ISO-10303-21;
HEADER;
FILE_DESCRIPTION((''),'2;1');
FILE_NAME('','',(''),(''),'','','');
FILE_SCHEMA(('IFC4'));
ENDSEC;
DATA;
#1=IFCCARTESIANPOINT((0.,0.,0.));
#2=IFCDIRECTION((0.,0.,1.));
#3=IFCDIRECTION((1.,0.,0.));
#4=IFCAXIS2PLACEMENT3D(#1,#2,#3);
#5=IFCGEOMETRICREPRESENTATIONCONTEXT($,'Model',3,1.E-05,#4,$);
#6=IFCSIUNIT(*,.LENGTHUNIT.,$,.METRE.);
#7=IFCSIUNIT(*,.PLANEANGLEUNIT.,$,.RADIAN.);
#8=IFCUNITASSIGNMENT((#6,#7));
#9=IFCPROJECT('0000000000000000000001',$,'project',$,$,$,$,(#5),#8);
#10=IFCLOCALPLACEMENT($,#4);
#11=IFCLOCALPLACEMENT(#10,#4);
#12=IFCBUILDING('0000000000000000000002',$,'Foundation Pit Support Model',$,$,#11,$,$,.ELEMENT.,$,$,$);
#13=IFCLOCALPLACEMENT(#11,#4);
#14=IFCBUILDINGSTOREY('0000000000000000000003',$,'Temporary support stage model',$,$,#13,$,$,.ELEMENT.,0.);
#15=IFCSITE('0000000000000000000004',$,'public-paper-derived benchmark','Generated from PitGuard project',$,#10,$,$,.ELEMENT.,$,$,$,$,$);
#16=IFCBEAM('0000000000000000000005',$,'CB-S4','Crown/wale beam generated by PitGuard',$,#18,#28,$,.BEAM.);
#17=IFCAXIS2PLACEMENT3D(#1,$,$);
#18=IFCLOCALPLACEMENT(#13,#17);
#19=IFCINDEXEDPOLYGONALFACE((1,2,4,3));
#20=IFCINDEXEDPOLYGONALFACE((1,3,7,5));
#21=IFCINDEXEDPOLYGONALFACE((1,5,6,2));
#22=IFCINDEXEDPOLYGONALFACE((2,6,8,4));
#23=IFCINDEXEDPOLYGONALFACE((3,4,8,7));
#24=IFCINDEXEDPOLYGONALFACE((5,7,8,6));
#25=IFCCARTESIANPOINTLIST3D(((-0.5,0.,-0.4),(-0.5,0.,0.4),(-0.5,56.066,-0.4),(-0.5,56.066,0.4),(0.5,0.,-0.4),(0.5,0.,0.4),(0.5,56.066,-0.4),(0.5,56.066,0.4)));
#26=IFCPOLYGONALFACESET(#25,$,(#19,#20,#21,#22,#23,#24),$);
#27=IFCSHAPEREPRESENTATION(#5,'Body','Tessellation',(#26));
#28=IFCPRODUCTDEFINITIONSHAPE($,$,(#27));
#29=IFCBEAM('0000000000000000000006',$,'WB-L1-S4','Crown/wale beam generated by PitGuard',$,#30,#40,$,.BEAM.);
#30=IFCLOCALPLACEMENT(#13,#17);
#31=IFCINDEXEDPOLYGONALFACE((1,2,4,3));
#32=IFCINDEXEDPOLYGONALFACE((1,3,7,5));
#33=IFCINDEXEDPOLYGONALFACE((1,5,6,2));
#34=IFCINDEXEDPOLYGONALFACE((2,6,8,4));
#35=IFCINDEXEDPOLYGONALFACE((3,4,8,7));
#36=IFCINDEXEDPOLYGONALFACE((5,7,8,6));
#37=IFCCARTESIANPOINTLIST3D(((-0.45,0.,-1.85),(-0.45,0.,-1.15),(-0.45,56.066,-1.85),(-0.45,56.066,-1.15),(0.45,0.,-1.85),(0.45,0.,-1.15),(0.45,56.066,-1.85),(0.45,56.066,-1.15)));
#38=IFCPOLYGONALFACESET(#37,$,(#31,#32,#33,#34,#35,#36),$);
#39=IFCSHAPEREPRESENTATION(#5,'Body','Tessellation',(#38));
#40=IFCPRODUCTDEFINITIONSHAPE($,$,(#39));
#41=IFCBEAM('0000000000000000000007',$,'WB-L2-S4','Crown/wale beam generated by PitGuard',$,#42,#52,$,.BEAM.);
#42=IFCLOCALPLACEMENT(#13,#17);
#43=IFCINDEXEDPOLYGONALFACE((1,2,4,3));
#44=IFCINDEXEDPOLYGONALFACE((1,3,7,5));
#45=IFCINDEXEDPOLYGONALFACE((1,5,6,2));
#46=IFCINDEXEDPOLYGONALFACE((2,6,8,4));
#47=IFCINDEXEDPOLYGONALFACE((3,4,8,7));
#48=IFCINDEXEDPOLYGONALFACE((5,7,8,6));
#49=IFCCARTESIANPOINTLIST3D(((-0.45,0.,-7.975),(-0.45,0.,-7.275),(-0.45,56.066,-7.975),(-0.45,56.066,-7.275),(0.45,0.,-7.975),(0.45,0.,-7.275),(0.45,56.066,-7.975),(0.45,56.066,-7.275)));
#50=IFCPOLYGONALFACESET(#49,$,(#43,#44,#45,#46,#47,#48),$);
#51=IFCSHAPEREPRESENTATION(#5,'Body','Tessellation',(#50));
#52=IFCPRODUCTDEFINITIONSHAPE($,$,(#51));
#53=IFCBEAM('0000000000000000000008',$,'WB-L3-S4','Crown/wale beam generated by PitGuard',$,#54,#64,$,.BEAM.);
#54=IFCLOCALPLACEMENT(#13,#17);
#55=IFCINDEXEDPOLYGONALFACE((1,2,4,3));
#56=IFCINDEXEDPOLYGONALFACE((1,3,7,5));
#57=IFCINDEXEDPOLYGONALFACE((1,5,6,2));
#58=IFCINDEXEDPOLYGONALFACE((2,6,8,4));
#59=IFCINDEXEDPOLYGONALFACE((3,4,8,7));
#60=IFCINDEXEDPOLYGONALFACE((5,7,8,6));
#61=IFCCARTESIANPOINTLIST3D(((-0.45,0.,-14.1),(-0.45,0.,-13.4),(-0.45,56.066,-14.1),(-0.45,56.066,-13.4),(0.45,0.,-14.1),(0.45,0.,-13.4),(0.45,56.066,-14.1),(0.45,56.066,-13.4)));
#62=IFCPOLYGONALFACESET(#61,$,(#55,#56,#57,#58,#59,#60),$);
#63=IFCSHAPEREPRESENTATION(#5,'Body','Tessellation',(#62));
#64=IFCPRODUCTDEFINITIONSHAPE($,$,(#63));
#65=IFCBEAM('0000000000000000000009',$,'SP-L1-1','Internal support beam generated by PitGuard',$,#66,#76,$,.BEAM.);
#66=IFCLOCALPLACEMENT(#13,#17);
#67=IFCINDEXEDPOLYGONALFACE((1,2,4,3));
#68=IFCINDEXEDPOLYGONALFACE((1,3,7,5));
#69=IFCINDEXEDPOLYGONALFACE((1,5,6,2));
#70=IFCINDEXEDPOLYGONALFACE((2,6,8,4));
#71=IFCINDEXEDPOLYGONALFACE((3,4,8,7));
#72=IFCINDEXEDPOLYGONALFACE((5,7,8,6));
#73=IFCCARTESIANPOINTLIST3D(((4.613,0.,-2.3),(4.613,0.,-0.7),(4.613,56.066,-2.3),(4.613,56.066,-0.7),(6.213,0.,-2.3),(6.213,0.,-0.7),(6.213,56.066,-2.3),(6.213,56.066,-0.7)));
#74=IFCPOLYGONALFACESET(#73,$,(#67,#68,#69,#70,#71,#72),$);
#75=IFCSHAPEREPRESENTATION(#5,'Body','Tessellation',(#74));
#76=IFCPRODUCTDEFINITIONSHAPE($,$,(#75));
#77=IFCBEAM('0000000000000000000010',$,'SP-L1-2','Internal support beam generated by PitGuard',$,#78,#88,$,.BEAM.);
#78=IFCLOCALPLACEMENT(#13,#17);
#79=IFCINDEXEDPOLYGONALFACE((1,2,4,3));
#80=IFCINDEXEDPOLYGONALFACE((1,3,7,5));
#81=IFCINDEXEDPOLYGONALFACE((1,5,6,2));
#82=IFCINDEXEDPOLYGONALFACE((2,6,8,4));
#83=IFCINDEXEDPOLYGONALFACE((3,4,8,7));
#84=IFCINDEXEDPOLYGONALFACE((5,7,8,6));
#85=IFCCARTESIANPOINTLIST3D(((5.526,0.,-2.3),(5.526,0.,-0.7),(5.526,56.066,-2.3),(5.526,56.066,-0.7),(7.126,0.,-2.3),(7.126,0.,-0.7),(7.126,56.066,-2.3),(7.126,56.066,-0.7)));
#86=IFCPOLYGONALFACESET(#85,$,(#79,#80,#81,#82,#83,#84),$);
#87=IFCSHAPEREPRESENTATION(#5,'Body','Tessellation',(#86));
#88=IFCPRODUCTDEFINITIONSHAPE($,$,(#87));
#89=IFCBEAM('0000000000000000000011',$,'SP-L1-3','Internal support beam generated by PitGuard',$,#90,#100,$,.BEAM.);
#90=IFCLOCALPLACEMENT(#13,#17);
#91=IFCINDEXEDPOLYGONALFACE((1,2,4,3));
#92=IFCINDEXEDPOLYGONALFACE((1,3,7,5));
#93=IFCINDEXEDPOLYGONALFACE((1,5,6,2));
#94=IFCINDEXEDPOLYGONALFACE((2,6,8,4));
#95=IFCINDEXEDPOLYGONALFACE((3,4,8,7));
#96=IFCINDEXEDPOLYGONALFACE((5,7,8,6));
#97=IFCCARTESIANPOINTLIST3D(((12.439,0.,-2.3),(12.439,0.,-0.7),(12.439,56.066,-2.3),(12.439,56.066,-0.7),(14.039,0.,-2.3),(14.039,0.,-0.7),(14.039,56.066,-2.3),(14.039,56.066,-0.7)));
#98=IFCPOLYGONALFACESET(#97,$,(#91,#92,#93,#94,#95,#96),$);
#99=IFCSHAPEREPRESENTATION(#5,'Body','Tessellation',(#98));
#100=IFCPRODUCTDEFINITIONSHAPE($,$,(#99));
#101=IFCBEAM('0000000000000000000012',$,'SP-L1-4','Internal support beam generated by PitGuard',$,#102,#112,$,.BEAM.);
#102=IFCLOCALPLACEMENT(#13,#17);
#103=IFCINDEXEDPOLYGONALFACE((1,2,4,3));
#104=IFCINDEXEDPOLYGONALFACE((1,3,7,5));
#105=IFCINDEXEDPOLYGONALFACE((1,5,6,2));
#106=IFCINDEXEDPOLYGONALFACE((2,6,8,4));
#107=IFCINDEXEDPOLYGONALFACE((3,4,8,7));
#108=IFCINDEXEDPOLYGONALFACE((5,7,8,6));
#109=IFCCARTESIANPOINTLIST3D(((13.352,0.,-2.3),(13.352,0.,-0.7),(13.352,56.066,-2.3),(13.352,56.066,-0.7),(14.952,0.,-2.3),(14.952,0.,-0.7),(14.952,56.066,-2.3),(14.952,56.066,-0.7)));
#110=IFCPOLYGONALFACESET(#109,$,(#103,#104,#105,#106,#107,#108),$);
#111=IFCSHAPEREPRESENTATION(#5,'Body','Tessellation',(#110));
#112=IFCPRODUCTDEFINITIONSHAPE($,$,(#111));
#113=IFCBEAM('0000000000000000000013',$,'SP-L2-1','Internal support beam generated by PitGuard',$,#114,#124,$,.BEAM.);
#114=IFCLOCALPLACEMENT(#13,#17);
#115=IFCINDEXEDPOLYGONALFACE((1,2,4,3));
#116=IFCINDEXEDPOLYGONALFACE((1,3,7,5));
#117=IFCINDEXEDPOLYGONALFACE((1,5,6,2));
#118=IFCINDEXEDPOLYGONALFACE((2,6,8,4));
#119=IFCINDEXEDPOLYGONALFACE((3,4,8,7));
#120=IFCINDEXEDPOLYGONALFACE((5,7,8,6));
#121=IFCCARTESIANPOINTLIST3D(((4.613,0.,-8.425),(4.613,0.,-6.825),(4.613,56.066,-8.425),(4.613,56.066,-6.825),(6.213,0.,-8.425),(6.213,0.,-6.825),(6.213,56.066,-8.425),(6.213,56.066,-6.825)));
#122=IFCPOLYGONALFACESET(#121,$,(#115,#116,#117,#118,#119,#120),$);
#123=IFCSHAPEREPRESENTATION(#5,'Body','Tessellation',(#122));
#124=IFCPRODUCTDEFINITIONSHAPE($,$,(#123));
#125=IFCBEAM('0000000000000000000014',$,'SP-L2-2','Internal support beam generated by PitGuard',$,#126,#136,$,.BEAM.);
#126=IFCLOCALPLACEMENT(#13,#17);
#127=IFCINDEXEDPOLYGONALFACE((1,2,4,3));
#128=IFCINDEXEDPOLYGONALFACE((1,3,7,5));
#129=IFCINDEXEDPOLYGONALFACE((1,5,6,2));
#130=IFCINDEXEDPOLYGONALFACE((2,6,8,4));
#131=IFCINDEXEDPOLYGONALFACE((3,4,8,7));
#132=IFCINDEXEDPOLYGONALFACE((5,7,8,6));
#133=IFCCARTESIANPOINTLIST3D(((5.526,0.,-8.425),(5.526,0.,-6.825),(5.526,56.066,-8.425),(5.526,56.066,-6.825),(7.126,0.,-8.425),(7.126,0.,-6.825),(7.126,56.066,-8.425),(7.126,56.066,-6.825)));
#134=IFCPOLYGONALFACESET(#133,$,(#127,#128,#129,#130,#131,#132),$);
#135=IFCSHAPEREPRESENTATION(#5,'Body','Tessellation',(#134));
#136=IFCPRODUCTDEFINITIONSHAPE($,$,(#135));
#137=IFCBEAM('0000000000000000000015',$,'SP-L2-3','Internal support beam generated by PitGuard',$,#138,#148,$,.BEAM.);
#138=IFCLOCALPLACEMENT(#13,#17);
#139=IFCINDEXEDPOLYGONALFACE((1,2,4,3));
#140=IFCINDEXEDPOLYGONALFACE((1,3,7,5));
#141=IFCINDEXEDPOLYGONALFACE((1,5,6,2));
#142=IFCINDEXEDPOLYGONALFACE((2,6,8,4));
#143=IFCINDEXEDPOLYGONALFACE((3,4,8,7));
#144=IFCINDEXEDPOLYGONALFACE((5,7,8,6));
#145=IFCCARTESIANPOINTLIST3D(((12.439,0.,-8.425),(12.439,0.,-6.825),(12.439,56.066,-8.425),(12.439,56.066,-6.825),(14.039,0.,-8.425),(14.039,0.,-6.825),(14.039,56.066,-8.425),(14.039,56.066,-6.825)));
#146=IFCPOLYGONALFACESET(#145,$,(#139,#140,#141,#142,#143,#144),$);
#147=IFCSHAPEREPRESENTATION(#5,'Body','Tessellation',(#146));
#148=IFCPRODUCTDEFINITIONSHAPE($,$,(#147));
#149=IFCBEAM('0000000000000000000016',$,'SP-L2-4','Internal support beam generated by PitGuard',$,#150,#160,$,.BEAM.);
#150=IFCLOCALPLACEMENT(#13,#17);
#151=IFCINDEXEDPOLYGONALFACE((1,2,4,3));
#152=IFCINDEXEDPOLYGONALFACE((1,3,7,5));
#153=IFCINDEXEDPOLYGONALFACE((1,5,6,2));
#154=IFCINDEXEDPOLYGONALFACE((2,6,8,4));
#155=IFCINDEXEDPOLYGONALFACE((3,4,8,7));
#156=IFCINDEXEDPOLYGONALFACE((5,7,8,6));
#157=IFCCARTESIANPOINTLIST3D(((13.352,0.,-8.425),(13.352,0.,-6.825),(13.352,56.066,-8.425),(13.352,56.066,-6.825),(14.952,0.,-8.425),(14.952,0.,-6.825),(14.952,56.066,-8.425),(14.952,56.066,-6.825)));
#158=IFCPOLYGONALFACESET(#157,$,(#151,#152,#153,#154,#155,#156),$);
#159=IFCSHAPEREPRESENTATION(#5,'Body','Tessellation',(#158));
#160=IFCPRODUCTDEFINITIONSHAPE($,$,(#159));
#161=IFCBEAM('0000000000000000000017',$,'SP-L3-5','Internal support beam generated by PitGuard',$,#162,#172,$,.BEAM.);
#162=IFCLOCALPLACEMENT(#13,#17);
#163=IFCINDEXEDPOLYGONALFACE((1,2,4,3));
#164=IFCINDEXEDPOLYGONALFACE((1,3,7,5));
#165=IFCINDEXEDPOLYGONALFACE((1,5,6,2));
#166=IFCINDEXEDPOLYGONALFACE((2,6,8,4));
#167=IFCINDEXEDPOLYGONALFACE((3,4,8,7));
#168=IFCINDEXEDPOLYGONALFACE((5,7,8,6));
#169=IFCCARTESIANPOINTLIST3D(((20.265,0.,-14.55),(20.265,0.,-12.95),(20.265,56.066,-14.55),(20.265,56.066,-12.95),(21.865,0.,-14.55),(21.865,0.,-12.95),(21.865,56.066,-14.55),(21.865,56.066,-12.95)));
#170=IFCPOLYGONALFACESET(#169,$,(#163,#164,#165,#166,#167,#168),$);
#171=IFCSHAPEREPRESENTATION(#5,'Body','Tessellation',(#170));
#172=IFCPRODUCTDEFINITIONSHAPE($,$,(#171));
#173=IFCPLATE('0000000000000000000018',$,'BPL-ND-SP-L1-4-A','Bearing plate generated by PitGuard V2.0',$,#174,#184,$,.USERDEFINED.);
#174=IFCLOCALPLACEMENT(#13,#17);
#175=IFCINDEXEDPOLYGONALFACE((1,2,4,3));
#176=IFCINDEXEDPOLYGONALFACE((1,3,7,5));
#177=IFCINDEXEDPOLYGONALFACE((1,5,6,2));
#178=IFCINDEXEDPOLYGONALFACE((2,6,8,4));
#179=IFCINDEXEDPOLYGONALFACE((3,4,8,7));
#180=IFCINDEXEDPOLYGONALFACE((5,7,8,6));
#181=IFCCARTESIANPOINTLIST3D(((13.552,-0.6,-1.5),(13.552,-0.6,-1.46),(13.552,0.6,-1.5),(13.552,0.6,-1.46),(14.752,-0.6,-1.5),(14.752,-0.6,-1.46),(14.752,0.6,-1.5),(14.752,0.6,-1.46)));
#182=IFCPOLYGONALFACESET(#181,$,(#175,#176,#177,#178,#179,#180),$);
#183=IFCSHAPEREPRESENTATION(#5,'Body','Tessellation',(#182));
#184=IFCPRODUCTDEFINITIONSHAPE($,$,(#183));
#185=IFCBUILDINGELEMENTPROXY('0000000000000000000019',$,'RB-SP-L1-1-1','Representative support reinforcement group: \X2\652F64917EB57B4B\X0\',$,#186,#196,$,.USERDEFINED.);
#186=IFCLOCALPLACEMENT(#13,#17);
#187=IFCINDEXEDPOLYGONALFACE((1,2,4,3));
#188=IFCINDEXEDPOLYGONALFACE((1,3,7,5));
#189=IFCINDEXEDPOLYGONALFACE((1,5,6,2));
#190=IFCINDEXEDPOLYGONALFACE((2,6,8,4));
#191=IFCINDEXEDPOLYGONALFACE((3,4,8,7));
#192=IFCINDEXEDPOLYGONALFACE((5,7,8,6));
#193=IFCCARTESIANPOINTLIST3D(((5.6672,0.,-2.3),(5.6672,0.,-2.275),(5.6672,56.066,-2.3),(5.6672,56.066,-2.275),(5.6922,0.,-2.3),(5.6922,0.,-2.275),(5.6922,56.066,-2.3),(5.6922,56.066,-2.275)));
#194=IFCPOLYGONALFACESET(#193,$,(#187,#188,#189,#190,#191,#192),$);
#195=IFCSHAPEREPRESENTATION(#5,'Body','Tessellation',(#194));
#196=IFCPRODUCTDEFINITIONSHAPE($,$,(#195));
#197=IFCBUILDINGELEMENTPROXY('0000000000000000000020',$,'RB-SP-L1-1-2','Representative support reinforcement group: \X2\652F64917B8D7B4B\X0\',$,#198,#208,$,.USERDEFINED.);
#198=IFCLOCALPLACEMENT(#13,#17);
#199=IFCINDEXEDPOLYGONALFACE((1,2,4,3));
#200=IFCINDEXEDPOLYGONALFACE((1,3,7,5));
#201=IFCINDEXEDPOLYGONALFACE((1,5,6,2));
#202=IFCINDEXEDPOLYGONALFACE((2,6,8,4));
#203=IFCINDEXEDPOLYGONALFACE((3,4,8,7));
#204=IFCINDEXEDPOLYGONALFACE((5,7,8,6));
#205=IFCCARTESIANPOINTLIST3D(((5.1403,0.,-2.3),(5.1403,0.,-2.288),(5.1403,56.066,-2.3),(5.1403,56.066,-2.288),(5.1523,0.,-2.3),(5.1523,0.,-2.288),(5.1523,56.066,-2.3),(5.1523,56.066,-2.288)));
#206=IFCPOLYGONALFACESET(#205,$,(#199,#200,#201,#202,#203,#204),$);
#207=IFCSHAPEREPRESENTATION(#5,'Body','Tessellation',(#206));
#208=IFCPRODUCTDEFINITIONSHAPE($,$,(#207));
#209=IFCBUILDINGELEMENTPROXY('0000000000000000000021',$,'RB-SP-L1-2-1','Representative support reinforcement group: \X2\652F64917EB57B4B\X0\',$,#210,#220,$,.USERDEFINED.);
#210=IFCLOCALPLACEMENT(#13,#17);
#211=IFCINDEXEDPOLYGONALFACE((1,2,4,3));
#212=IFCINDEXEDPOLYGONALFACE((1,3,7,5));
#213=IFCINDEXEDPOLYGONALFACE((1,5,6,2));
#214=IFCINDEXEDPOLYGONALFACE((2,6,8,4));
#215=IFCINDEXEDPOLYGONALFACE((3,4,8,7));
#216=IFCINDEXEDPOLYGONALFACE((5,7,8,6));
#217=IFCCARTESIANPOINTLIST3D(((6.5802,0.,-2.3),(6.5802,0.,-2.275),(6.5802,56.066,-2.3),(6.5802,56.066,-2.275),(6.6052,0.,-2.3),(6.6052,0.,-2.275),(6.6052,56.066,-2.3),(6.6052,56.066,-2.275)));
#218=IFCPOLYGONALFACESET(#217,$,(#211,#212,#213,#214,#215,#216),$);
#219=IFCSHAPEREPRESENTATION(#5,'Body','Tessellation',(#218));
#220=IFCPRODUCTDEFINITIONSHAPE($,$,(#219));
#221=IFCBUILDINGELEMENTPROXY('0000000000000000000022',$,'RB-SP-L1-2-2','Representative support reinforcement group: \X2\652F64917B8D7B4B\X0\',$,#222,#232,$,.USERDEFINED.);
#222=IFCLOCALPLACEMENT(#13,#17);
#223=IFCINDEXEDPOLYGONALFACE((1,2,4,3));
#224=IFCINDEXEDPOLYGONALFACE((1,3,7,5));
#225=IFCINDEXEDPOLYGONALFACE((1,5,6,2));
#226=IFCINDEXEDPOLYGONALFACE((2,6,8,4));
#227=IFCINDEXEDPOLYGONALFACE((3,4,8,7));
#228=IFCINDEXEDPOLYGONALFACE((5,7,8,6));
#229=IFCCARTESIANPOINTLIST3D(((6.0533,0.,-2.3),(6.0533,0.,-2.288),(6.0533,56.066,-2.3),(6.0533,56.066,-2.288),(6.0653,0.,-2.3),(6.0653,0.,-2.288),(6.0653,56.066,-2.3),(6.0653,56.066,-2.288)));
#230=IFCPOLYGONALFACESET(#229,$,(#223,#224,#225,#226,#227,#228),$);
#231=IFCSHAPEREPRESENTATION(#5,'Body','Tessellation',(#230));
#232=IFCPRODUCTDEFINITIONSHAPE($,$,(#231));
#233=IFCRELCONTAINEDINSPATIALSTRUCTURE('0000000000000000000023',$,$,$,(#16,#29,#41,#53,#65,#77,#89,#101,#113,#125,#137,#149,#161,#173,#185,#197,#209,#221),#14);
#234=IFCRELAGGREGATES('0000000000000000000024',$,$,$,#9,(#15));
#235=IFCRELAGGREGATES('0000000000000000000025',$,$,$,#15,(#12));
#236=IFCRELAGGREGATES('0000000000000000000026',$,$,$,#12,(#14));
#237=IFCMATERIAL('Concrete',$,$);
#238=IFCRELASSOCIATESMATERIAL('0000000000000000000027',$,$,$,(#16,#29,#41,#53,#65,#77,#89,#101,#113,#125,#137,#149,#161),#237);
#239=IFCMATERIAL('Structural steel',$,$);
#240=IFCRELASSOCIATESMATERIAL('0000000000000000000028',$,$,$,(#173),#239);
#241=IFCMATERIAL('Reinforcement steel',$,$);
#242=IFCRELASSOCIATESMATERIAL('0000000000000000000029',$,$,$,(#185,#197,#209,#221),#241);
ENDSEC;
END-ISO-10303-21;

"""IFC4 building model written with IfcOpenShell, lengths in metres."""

from ifc_helpers import new_model, si_unit, frame, origin_with_axes, origin_2d, place, context, project, spatial, rectangle, extrude, material, element, save


model = new_model("IFC4")

# Units and contexts
model_context = context("Model", 3, precision=1e-05, world=origin_with_axes())
ifc_project = project(units=[si_unit("LENGTHUNIT", "METRE"), si_unit("PLANEANGLEUNIT", "RADIAN")], contexts=[model_context])

# Site, building, storey
site_placement = place(None, origin_with_axes())
site = spatial("IfcSite", under=ifc_project, at=site_placement, Name="public-paper-derived benchmark", Description="Generated from PitGuard project", CompositionType="ELEMENT")
building_placement = place(site_placement, origin_with_axes())
building = spatial("IfcBuilding", under=site, at=building_placement, Name="Foundation Pit Support Model", CompositionType="ELEMENT")
storey_placement = place(building_placement, origin_with_axes())
storey = spatial("IfcBuildingStorey", under=building, at=storey_placement, Name="Temporary support stage model", CompositionType="ELEMENT", Elevation=0.0)

# Beams
ifc_material_1 = material(Name="Concrete")
beam_placement = place(storey_placement, frame((0.0, 28.033, -0.4), z_axis=(0.0, 0.0, 1.0), x_axis=(0.0, -1.0, 0.0)))
element("IfcBeam", 1, at=beam_placement, inside=storey, material=ifc_material_1, Name="CB-S4", Description="Crown/wale beam generated by PitGuard", PredefinedType="BEAM", context=model_context, shape_type="SweptSolid", body=[
    extrude(rectangle(XDim=56.066, YDim=1.0, at=origin_2d()), origin_with_axes(), (0.0, 0.0, 1.0), 0.8),
])
for number, where, z_axis, x_axis, name in (
    (2, (0.0, 28.033, -1.85), (0.0, 0.0, 1.0), (0.0, -1.0, 0.0), "WB-L1-S4"),
    (3, (0.0, 28.033, -7.975), (0.0, 0.0, 1.0), (0.0, -1.0, 0.0), "WB-L2-S4"),
    (4, (0.0, 28.033, -14.1), (0.0, 0.0, 1.0), (0.0, -1.0, 0.0), "WB-L3-S4"),
):
    element("IfcBeam", number, at=place(storey_placement, frame(where, z_axis=z_axis, x_axis=x_axis)), inside=storey, material=ifc_material_1, Name=name, Description="Crown/wale beam generated by PitGuard", PredefinedType="BEAM", context=model_context, shape_type="SweptSolid", body=[
        extrude(rectangle(XDim=56.066, YDim=0.9, at=origin_2d()), origin_with_axes(), (0.0, 0.0, 1.0), 0.7),
    ])
for number, where, z_axis, x_axis, name in (
    (5, (5.413, 28.033, -2.3), (0.0, 0.0, 1.0), (0.0, 1.0, 0.0), "SP-L1-1"),
    (6, (6.326, 28.033, -2.3), (0.0, 0.0, 1.0), (0.0, 1.0, 0.0), "SP-L1-2"),
    (7, (13.239, 28.033, -2.3), (0.0, 0.0, 1.0), (0.0, 1.0, 0.0), "SP-L1-3"),
    (8, (14.152, 28.033, -2.3), (0.0, 0.0, 1.0), (0.0, 1.0, 0.0), "SP-L1-4"),
    (9, (5.413, 28.033, -8.425), (0.0, 0.0, 1.0), (0.0, 1.0, 0.0), "SP-L2-1"),
    (10, (6.326, 28.033, -8.425), (0.0, 0.0, 1.0), (0.0, 1.0, 0.0), "SP-L2-2"),
    (11, (13.239, 28.033, -8.425), (0.0, 0.0, 1.0), (0.0, 1.0, 0.0), "SP-L2-3"),
    (12, (14.152, 28.033, -8.425), (0.0, 0.0, 1.0), (0.0, 1.0, 0.0), "SP-L2-4"),
    (13, (21.065, 28.033, -14.55), (0.0, 0.0, 1.0), (0.0, 1.0, 0.0), "SP-L3-5"),
):
    element("IfcBeam", number, at=place(storey_placement, frame(where, z_axis=z_axis, x_axis=x_axis)), inside=storey, material=ifc_material_1, Name=name, Description="Internal support beam generated by PitGuard", PredefinedType="BEAM", context=model_context, shape_type="SweptSolid", body=[
        extrude(rectangle(XDim=56.066, YDim=1.6, at=origin_2d()), origin_with_axes(), (0.0, 0.0, 1.0), 1.6),
    ])

# Plate
ifc_material_2 = material(Name="Structural steel")
plate_placement = place(storey_placement, frame((14.152, 0.0, -1.5), z_axis=(0.0, 0.0, 1.0), x_axis=(1.0, 0.0, 0.0)))
element("IfcPlate", 14, at=plate_placement, inside=storey, material=ifc_material_2, Name="BPL-ND-SP-L1-4-A", Description="Bearing plate generated by PitGuard V2.0", PredefinedType="USERDEFINED", context=model_context, shape_type="SweptSolid", body=[
    extrude(rectangle(XDim=1.2, YDim=1.2, at=origin_2d()), origin_with_axes(), (0.0, 0.0, 1.0), 0.04),
])

# Building element proxies
ifc_material_3 = material(Name="Reinforcement steel")
proxy_1_placement = place(storey_placement, frame((5.6797, 28.033, -2.3), z_axis=(0.0, 0.0, 1.0), x_axis=(0.0, 1.0, 0.0)))
element("IfcBuildingElementProxy", 15, at=proxy_1_placement, inside=storey, material=ifc_material_3, Name="RB-SP-L1-1-1", Description="Representative support reinforcement group: 支撑纵筋", PredefinedType="USERDEFINED", context=model_context, shape_type="SweptSolid", body=[
    extrude(rectangle(XDim=56.066, YDim=0.025, at=origin_2d()), origin_with_axes(), (0.0, 0.0, 1.0), 0.025),
])
proxy_2_placement = place(storey_placement, frame((5.1463, 28.033, -2.3), z_axis=(0.0, 0.0, 1.0), x_axis=(0.0, 1.0, 0.0)))
element("IfcBuildingElementProxy", 16, at=proxy_2_placement, inside=storey, material=ifc_material_3, Name="RB-SP-L1-1-2", Description="Representative support reinforcement group: 支撑箍筋", PredefinedType="USERDEFINED", context=model_context, shape_type="SweptSolid", body=[
    extrude(rectangle(XDim=56.066, YDim=0.012, at=origin_2d()), origin_with_axes(), (0.0, 0.0, 1.0), 0.012),
])
proxy_3_placement = place(storey_placement, frame((6.5927, 28.033, -2.3), z_axis=(0.0, 0.0, 1.0), x_axis=(0.0, 1.0, 0.0)))
element("IfcBuildingElementProxy", 17, at=proxy_3_placement, inside=storey, material=ifc_material_3, Name="RB-SP-L1-2-1", Description="Representative support reinforcement group: 支撑纵筋", PredefinedType="USERDEFINED", context=model_context, shape_type="SweptSolid", body=[
    extrude(rectangle(XDim=56.066, YDim=0.025, at=origin_2d()), origin_with_axes(), (0.0, 0.0, 1.0), 0.025),
])
proxy_4_placement = place(storey_placement, frame((6.0593, 28.033, -2.3), z_axis=(0.0, 0.0, 1.0), x_axis=(0.0, 1.0, 0.0)))
element("IfcBuildingElementProxy", 18, at=proxy_4_placement, inside=storey, material=ifc_material_3, Name="RB-SP-L1-2-2", Description="Representative support reinforcement group: 支撑箍筋", PredefinedType="USERDEFINED", context=model_context, shape_type="SweptSolid", body=[
    extrude(rectangle(XDim=56.066, YDim=0.012, at=origin_2d()), origin_with_axes(), (0.0, 0.0, 1.0), 0.012),
])

save(model, "model.ifc")
